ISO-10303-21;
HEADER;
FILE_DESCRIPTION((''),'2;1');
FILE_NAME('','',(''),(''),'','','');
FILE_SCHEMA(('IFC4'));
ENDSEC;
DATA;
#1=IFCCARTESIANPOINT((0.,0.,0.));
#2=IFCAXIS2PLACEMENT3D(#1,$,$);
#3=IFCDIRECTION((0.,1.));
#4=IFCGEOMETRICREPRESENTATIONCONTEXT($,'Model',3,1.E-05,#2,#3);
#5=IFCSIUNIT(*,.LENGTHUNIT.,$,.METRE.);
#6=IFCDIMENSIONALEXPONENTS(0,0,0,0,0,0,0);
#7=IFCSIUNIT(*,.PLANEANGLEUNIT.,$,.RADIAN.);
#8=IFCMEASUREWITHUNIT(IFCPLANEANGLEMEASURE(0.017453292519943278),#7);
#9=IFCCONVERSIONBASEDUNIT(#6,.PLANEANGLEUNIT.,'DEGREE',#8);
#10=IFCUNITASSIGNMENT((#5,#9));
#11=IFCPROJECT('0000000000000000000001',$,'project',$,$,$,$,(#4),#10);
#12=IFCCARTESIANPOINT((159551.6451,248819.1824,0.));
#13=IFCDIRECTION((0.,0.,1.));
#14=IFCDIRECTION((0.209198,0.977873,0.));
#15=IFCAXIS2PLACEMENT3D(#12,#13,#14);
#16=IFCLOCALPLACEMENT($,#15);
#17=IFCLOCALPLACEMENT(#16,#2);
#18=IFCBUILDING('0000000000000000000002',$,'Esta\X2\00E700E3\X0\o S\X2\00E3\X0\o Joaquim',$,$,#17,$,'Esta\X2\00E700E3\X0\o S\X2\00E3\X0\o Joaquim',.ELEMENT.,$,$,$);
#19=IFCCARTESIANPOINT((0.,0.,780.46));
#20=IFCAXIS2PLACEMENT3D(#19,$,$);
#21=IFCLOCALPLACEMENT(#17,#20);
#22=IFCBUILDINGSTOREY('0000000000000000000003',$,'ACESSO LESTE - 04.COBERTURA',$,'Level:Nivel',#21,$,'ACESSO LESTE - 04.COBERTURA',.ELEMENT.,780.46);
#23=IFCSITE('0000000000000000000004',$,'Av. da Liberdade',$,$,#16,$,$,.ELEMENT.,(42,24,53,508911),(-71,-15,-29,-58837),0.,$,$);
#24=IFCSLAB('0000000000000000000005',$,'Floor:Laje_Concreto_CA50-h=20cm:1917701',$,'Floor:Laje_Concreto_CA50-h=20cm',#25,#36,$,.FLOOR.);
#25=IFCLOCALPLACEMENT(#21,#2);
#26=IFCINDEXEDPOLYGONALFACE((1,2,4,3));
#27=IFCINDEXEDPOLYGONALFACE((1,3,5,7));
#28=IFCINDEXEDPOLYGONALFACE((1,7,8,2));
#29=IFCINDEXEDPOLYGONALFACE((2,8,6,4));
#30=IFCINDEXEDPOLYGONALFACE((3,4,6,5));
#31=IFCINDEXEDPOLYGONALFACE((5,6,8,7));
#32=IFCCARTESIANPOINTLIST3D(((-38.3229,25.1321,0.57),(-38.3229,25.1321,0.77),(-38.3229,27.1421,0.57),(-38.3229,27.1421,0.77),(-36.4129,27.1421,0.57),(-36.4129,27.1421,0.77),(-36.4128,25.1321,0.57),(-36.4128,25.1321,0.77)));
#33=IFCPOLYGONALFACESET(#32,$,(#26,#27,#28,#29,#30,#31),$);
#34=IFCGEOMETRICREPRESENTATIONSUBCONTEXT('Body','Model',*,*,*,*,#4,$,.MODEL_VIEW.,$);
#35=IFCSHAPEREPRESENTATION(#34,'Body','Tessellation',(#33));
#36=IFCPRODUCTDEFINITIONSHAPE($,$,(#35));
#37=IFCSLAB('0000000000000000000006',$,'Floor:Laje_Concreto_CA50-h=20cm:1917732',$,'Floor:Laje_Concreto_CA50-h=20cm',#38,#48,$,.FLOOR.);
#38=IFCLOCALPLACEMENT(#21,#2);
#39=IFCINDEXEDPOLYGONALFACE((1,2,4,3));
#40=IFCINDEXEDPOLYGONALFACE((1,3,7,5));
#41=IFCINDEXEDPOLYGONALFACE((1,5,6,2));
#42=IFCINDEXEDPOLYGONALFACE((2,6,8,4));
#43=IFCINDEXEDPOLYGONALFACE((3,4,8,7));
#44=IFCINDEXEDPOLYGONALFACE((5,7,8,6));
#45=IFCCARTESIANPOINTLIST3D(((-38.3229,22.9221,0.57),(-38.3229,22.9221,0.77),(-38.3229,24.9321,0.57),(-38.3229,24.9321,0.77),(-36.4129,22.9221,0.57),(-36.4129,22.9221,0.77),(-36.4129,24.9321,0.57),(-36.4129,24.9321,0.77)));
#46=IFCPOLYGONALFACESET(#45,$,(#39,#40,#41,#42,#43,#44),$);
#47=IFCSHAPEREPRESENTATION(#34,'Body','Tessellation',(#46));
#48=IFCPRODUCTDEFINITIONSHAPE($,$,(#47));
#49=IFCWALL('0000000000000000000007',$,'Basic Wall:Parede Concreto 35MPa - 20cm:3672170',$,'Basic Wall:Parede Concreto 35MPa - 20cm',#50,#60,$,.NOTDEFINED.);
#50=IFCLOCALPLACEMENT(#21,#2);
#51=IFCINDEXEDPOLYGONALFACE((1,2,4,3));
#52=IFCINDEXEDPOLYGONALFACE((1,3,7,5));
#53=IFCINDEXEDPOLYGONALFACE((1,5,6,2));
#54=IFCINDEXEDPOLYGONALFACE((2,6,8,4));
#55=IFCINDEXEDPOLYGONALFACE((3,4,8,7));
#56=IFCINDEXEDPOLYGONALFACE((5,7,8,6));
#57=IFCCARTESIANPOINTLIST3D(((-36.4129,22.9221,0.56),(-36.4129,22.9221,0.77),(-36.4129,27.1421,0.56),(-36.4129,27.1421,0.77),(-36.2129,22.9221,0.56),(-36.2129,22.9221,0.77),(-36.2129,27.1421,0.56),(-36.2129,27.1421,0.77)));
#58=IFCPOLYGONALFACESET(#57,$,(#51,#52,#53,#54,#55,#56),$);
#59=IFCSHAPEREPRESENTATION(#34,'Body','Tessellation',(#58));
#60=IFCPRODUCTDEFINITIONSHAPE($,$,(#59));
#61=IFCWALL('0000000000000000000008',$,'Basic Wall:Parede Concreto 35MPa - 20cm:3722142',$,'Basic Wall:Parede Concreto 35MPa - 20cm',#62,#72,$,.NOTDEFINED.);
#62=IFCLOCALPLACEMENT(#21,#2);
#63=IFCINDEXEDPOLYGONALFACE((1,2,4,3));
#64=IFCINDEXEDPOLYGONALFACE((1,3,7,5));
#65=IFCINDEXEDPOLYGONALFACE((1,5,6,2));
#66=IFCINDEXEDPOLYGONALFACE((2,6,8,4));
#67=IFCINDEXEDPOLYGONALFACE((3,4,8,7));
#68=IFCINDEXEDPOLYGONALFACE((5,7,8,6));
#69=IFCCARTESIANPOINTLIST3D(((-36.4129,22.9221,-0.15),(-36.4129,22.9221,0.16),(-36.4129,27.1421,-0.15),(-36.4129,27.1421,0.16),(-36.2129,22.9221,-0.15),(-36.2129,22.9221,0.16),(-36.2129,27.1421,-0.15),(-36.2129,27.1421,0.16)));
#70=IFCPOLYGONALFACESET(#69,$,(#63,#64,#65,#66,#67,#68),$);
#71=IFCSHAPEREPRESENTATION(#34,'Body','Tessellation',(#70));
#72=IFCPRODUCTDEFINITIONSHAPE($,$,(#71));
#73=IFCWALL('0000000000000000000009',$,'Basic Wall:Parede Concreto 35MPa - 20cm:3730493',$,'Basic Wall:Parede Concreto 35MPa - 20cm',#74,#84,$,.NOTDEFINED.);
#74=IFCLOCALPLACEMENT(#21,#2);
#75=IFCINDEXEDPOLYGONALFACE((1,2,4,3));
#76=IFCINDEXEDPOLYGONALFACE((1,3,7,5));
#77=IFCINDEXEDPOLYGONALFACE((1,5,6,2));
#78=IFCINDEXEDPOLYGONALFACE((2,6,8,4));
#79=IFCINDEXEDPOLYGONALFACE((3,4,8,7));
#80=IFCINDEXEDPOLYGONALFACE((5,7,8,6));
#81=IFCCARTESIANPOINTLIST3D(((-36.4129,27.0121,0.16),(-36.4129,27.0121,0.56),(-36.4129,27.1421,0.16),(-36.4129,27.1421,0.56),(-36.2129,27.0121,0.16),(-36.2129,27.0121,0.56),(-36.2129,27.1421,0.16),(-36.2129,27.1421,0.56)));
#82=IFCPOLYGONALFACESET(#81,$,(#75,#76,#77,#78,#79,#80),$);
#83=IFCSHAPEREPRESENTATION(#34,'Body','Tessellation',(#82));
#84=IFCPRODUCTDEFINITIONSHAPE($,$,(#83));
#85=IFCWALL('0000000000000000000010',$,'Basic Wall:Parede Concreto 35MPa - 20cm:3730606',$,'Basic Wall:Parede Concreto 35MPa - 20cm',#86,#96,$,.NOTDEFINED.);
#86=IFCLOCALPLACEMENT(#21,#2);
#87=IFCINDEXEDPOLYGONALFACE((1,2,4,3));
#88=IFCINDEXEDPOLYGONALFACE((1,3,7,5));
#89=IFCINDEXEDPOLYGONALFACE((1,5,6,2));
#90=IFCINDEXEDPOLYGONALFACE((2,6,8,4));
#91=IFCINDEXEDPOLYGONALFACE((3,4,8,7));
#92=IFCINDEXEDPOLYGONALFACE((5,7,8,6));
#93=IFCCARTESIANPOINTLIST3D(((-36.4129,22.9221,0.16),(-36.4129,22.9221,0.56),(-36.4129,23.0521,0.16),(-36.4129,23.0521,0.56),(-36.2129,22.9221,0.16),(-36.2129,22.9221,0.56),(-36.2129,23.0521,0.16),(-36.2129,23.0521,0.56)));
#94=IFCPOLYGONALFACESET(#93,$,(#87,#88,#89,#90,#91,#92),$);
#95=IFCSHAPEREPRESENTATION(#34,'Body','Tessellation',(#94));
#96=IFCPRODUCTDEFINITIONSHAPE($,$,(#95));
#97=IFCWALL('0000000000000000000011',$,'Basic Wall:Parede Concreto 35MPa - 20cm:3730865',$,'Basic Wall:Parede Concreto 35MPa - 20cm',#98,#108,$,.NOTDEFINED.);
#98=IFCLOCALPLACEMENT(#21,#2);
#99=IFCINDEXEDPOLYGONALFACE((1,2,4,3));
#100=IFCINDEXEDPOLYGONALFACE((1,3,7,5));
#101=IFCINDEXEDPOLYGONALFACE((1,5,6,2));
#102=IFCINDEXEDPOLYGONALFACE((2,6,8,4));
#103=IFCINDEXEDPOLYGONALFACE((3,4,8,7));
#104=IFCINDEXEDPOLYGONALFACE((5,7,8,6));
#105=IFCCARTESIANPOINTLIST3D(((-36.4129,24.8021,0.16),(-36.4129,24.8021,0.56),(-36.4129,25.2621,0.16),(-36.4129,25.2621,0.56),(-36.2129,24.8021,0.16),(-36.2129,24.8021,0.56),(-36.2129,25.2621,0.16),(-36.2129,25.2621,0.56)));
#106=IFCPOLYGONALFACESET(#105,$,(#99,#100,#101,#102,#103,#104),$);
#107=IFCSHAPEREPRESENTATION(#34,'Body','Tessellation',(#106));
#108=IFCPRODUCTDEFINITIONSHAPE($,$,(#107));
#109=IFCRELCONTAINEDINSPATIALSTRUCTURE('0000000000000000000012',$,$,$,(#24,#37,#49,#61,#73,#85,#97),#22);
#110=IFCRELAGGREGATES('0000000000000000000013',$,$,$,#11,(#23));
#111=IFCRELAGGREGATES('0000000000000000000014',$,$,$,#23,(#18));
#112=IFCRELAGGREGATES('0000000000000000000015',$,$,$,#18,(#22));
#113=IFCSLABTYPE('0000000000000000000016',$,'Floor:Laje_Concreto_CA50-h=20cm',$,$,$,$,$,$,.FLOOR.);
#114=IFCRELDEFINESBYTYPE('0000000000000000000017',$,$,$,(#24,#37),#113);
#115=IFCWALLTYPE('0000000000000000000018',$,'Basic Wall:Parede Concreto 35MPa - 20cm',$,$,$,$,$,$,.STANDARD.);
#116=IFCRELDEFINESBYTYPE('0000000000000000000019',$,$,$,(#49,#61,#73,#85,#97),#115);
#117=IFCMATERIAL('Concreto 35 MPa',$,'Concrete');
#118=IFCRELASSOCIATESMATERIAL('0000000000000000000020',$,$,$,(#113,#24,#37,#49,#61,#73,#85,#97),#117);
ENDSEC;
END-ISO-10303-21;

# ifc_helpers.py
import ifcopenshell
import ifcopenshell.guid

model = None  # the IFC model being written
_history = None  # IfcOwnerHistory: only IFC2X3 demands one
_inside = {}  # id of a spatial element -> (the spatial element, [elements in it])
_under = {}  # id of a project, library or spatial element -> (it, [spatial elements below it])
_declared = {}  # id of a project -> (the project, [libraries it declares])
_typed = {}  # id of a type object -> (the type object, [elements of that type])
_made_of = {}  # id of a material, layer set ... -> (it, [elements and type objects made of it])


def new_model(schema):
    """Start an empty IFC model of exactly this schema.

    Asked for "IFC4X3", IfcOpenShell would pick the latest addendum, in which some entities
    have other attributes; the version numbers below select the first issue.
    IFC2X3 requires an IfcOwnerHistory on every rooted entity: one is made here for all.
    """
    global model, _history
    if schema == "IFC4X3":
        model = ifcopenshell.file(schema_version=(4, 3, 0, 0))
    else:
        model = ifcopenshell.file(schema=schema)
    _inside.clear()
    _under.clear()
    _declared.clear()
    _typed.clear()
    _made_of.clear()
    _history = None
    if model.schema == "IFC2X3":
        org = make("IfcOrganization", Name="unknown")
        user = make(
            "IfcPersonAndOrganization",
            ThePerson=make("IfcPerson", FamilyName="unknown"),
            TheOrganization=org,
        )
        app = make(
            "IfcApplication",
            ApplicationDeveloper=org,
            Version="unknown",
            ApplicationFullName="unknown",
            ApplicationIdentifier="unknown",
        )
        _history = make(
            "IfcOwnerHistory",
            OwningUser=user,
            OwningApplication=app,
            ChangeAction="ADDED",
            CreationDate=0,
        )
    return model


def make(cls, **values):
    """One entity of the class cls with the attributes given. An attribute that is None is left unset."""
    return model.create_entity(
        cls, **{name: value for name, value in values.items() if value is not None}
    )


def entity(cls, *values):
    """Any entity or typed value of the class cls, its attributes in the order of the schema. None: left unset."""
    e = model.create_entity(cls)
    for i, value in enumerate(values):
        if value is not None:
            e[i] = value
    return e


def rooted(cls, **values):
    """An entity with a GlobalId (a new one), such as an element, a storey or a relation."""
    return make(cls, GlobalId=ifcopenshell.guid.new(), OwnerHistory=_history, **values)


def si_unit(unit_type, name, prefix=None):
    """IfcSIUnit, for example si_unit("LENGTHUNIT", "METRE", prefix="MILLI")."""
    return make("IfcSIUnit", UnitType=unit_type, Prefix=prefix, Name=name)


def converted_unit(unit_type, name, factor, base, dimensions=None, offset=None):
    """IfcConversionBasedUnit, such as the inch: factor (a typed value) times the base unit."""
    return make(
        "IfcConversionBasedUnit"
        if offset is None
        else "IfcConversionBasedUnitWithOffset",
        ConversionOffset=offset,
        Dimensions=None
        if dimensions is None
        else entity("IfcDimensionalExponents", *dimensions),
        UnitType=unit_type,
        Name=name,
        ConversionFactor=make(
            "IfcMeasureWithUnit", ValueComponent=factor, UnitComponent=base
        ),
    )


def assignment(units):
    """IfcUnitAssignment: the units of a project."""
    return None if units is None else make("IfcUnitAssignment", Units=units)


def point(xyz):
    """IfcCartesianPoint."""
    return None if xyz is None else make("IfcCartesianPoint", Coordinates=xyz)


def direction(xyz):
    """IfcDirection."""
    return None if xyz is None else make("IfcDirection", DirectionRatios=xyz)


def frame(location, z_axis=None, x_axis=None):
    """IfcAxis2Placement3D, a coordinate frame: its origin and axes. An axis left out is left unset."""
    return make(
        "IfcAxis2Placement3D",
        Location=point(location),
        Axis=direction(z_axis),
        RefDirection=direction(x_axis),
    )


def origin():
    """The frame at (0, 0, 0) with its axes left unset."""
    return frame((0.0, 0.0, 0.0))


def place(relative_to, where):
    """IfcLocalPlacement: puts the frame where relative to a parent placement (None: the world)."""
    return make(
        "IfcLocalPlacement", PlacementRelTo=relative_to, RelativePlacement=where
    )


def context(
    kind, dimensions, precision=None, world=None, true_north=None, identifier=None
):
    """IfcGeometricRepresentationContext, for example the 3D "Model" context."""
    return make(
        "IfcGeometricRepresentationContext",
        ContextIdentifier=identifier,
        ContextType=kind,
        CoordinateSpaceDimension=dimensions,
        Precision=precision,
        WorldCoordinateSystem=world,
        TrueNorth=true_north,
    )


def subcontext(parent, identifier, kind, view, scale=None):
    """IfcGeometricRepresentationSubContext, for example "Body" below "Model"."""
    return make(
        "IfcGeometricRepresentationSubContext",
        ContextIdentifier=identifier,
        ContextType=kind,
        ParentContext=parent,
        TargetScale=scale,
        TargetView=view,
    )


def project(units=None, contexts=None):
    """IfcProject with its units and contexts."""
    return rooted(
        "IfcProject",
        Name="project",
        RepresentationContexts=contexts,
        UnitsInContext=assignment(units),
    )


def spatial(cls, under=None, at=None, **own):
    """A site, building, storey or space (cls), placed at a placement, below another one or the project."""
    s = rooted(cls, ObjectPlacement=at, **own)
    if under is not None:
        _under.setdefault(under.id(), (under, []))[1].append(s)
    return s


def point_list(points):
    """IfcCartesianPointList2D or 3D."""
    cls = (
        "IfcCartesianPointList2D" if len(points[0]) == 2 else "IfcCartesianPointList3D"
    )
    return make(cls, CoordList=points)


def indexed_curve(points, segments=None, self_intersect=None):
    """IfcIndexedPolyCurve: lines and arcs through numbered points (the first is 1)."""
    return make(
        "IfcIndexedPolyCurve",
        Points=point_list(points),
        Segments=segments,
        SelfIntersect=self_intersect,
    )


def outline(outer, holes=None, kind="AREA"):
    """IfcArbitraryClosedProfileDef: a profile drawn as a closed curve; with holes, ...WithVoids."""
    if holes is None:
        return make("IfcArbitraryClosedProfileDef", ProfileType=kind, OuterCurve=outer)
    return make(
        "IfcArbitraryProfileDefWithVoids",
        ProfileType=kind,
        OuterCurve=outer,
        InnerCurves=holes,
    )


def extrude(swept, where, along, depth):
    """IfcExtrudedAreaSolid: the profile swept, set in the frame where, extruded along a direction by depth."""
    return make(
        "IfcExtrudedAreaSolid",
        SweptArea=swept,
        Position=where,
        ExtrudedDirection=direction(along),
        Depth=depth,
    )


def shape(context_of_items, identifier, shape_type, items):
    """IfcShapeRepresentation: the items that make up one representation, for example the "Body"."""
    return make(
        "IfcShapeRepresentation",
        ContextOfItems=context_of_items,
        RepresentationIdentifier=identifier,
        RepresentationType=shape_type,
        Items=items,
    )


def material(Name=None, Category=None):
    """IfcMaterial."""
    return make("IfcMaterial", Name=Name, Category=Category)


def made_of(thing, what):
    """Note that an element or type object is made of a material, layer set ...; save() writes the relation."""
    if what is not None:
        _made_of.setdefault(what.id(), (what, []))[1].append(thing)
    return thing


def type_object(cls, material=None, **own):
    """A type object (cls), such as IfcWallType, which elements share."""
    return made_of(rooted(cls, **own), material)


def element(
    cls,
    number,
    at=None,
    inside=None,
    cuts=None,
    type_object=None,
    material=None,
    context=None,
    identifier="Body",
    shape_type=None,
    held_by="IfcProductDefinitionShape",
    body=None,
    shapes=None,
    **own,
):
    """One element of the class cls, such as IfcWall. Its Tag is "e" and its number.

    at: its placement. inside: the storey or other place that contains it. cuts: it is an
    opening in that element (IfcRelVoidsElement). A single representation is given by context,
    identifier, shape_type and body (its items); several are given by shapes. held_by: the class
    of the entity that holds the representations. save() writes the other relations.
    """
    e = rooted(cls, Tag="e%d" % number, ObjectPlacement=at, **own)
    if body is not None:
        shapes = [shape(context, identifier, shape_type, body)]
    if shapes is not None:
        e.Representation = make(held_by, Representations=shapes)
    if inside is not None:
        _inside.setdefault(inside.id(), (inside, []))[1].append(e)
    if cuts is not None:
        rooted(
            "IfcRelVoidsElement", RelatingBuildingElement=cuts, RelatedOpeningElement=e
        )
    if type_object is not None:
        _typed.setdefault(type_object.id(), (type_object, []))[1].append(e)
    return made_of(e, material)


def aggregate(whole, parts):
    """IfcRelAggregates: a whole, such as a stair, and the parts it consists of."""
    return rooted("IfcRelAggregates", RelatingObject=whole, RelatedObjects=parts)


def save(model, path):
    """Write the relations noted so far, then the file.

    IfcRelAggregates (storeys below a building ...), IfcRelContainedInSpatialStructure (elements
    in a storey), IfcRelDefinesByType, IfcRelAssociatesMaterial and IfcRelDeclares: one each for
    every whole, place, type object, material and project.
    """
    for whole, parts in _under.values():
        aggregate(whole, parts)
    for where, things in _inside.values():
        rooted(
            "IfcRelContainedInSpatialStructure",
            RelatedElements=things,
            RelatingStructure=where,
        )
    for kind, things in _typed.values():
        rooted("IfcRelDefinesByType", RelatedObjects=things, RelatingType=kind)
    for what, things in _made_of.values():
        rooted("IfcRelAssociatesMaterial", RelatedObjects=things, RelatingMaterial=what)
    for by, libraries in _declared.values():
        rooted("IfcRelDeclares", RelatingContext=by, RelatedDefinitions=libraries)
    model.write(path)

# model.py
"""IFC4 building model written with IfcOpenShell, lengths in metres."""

from ifc_helpers import new_model, entity, si_unit, converted_unit, direction, frame, origin, place, context, subcontext, project, spatial, indexed_curve, outline, extrude, material, type_object, element, save


model = new_model("IFC4")

# Units and contexts
model_context = context("Model", 3, precision=1e-05, world=origin(), true_north=direction((0.0, 1.0)))
body_context = subcontext(model_context, "Body", "Model", "MODEL_VIEW")
ifc_project = project(units=[si_unit("LENGTHUNIT", "METRE"), converted_unit("PLANEANGLEUNIT", "DEGREE", entity("IfcPlaneAngleMeasure", 0.017453292519943278), si_unit("PLANEANGLEUNIT", "RADIAN"), dimensions=[0, 0, 0, 0, 0, 0, 0])], contexts=[model_context])

# Site, building, storey
site_placement = place(None, frame((159551.6451, 248819.1824, 0.0), z_axis=(0.0, 0.0, 1.0), x_axis=(0.209198, 0.977873, 0.0)))
site = spatial("IfcSite", under=ifc_project, at=site_placement, Name="Av. da Liberdade", CompositionType="ELEMENT", RefLatitude=(42, 24, 53, 508911), RefLongitude=(-71, -15, -29, -58837), RefElevation=0.0)
building_placement = place(site_placement, origin())
building = spatial("IfcBuilding", under=site, at=building_placement, Name="Estação São Joaquim", LongName="Estação São Joaquim", CompositionType="ELEMENT")
storey_placement = place(building_placement, frame((0.0, 0.0, 780.46)))
storey = spatial("IfcBuildingStorey", under=building, at=storey_placement, Name="ACESSO LESTE - 04.COBERTURA", ObjectType="Level:Nivel", LongName="ACESSO LESTE - 04.COBERTURA", CompositionType="ELEMENT", Elevation=780.46)

# Slabs
ifc_material_1 = material(Name="Concreto 35 MPa", Category="Concrete")
slab_type_1 = type_object("IfcSlabType", Name="Floor:Laje_Concreto_CA50-h=20cm", PredefinedType="FLOOR", material=ifc_material_1)
slab_1_placement = place(storey_placement, origin())
element("IfcSlab", 1, at=slab_1_placement, inside=storey, type_object=slab_type_1, material=ifc_material_1, Name="Floor:Laje_Concreto_CA50-h=20cm:1917701", ObjectType="Floor:Laje_Concreto_CA50-h=20cm", PredefinedType="FLOOR", context=body_context, shape_type="SweptSolid", body=[
    extrude(outline(indexed_curve([(-0.955, -1.005), (0.955, -1.005), (0.955, 1.005), (-0.955, 1.005), (-0.955, -1.005)], self_intersect=False)), frame((-37.3679, 26.1371, 0.77), z_axis=(0.0, 0.0, -1.0), x_axis=(1.0, 0.000007, 0.0)), (0.0, 0.0, 1.0), 0.2),
])
slab_2_placement = place(storey_placement, origin())
element("IfcSlab", 2, at=slab_2_placement, inside=storey, type_object=slab_type_1, material=ifc_material_1, Name="Floor:Laje_Concreto_CA50-h=20cm:1917732", ObjectType="Floor:Laje_Concreto_CA50-h=20cm", PredefinedType="FLOOR", context=body_context, shape_type="SweptSolid", body=[
    extrude(outline(indexed_curve([(-0.955, -1.005), (0.955, -1.005), (0.955, 1.005), (-0.955, 1.005), (-0.955, -1.005)], self_intersect=False)), frame((-37.3679, 23.9271, 0.77), z_axis=(0.0, 0.0, -1.0), x_axis=(1.0, -0.000002, 0.0)), (0.0, 0.0, 1.0), 0.2),
])

# Walls
wall_type = type_object("IfcWallType", Name="Basic Wall:Parede Concreto 35MPa - 20cm", PredefinedType="STANDARD")
wall_1_placement = place(storey_placement, frame((-36.3129, 27.1421, 0.56), z_axis=(0.0, 0.0, 1.0), x_axis=(0.0, -1.0, 0.0)))
element("IfcWall", 3, at=wall_1_placement, inside=storey, type_object=wall_type, material=ifc_material_1, Name="Basic Wall:Parede Concreto 35MPa - 20cm:3672170", ObjectType="Basic Wall:Parede Concreto 35MPa - 20cm", PredefinedType="NOTDEFINED", context=body_context, shape_type="SweptSolid", body=[
    extrude(outline(indexed_curve([(4.2201, 0.1), (0.0, 0.1), (0.0, -0.1), (4.2201, -0.1), (4.2201, 0.1)], self_intersect=False)), origin(), (0.0, 0.0, 1.0), 0.21),
])
wall_2_placement = place(storey_placement, frame((-36.3129, 27.1421, -0.15), z_axis=(0.0, 0.0, 1.0), x_axis=(0.0, -1.0, 0.0)))
element("IfcWall", 4, at=wall_2_placement, inside=storey, type_object=wall_type, material=ifc_material_1, Name="Basic Wall:Parede Concreto 35MPa - 20cm:3722142", ObjectType="Basic Wall:Parede Concreto 35MPa - 20cm", PredefinedType="NOTDEFINED", context=body_context, shape_type="SweptSolid", body=[
    extrude(outline(indexed_curve([(4.2201, 0.1), (0.0, 0.1), (0.0, -0.1), (4.2201, -0.1), (4.2201, 0.1)], self_intersect=False)), origin(), (0.0, 0.0, 1.0), 0.31),
])
wall_3_placement = place(storey_placement, frame((-36.3129, 27.1421, 0.16), z_axis=(0.0, 0.0, 1.0), x_axis=(0.0, -1.0, 0.0)))
element("IfcWall", 5, at=wall_3_placement, inside=storey, type_object=wall_type, material=ifc_material_1, Name="Basic Wall:Parede Concreto 35MPa - 20cm:3730493", ObjectType="Basic Wall:Parede Concreto 35MPa - 20cm", PredefinedType="NOTDEFINED", context=body_context, shape_type="SweptSolid", body=[
    extrude(outline(indexed_curve([(0.13, 0.1), (0.0, 0.1), (0.0, -0.1), (0.13, -0.1), (0.13, 0.1)], self_intersect=False)), origin(), (0.0, 0.0, 1.0), 0.4),
])
wall_4_placement = place(storey_placement, frame((-36.3129, 23.0521, 0.16), z_axis=(0.0, 0.0, 1.0), x_axis=(0.0, -1.0, 0.0)))
element("IfcWall", 6, at=wall_4_placement, inside=storey, type_object=wall_type, material=ifc_material_1, Name="Basic Wall:Parede Concreto 35MPa - 20cm:3730606", ObjectType="Basic Wall:Parede Concreto 35MPa - 20cm", PredefinedType="NOTDEFINED", context=body_context, shape_type="SweptSolid", body=[
    extrude(outline(indexed_curve([(0.13, 0.1), (0.0, 0.1), (0.0, -0.1), (0.13, -0.1), (0.13, 0.1)], self_intersect=False)), origin(), (0.0, 0.0, 1.0), 0.4),
])
wall_5_placement = place(storey_placement, frame((-36.3129, 25.2621, 0.16), z_axis=(0.0, 0.0, 1.0), x_axis=(0.0, -1.0, 0.0)))
element("IfcWall", 7, at=wall_5_placement, inside=storey, type_object=wall_type, material=ifc_material_1, Name="Basic Wall:Parede Concreto 35MPa - 20cm:3730865", ObjectType="Basic Wall:Parede Concreto 35MPa - 20cm", PredefinedType="NOTDEFINED", context=body_context, shape_type="SweptSolid", body=[
    extrude(outline(indexed_curve([(0.46, 0.1), (0.0, 0.1), (0.0, -0.1), (0.46, -0.1), (0.46, 0.1)], self_intersect=False)), origin(), (0.0, 0.0, 1.0), 0.4),
])

save(model, "model.ifc")
